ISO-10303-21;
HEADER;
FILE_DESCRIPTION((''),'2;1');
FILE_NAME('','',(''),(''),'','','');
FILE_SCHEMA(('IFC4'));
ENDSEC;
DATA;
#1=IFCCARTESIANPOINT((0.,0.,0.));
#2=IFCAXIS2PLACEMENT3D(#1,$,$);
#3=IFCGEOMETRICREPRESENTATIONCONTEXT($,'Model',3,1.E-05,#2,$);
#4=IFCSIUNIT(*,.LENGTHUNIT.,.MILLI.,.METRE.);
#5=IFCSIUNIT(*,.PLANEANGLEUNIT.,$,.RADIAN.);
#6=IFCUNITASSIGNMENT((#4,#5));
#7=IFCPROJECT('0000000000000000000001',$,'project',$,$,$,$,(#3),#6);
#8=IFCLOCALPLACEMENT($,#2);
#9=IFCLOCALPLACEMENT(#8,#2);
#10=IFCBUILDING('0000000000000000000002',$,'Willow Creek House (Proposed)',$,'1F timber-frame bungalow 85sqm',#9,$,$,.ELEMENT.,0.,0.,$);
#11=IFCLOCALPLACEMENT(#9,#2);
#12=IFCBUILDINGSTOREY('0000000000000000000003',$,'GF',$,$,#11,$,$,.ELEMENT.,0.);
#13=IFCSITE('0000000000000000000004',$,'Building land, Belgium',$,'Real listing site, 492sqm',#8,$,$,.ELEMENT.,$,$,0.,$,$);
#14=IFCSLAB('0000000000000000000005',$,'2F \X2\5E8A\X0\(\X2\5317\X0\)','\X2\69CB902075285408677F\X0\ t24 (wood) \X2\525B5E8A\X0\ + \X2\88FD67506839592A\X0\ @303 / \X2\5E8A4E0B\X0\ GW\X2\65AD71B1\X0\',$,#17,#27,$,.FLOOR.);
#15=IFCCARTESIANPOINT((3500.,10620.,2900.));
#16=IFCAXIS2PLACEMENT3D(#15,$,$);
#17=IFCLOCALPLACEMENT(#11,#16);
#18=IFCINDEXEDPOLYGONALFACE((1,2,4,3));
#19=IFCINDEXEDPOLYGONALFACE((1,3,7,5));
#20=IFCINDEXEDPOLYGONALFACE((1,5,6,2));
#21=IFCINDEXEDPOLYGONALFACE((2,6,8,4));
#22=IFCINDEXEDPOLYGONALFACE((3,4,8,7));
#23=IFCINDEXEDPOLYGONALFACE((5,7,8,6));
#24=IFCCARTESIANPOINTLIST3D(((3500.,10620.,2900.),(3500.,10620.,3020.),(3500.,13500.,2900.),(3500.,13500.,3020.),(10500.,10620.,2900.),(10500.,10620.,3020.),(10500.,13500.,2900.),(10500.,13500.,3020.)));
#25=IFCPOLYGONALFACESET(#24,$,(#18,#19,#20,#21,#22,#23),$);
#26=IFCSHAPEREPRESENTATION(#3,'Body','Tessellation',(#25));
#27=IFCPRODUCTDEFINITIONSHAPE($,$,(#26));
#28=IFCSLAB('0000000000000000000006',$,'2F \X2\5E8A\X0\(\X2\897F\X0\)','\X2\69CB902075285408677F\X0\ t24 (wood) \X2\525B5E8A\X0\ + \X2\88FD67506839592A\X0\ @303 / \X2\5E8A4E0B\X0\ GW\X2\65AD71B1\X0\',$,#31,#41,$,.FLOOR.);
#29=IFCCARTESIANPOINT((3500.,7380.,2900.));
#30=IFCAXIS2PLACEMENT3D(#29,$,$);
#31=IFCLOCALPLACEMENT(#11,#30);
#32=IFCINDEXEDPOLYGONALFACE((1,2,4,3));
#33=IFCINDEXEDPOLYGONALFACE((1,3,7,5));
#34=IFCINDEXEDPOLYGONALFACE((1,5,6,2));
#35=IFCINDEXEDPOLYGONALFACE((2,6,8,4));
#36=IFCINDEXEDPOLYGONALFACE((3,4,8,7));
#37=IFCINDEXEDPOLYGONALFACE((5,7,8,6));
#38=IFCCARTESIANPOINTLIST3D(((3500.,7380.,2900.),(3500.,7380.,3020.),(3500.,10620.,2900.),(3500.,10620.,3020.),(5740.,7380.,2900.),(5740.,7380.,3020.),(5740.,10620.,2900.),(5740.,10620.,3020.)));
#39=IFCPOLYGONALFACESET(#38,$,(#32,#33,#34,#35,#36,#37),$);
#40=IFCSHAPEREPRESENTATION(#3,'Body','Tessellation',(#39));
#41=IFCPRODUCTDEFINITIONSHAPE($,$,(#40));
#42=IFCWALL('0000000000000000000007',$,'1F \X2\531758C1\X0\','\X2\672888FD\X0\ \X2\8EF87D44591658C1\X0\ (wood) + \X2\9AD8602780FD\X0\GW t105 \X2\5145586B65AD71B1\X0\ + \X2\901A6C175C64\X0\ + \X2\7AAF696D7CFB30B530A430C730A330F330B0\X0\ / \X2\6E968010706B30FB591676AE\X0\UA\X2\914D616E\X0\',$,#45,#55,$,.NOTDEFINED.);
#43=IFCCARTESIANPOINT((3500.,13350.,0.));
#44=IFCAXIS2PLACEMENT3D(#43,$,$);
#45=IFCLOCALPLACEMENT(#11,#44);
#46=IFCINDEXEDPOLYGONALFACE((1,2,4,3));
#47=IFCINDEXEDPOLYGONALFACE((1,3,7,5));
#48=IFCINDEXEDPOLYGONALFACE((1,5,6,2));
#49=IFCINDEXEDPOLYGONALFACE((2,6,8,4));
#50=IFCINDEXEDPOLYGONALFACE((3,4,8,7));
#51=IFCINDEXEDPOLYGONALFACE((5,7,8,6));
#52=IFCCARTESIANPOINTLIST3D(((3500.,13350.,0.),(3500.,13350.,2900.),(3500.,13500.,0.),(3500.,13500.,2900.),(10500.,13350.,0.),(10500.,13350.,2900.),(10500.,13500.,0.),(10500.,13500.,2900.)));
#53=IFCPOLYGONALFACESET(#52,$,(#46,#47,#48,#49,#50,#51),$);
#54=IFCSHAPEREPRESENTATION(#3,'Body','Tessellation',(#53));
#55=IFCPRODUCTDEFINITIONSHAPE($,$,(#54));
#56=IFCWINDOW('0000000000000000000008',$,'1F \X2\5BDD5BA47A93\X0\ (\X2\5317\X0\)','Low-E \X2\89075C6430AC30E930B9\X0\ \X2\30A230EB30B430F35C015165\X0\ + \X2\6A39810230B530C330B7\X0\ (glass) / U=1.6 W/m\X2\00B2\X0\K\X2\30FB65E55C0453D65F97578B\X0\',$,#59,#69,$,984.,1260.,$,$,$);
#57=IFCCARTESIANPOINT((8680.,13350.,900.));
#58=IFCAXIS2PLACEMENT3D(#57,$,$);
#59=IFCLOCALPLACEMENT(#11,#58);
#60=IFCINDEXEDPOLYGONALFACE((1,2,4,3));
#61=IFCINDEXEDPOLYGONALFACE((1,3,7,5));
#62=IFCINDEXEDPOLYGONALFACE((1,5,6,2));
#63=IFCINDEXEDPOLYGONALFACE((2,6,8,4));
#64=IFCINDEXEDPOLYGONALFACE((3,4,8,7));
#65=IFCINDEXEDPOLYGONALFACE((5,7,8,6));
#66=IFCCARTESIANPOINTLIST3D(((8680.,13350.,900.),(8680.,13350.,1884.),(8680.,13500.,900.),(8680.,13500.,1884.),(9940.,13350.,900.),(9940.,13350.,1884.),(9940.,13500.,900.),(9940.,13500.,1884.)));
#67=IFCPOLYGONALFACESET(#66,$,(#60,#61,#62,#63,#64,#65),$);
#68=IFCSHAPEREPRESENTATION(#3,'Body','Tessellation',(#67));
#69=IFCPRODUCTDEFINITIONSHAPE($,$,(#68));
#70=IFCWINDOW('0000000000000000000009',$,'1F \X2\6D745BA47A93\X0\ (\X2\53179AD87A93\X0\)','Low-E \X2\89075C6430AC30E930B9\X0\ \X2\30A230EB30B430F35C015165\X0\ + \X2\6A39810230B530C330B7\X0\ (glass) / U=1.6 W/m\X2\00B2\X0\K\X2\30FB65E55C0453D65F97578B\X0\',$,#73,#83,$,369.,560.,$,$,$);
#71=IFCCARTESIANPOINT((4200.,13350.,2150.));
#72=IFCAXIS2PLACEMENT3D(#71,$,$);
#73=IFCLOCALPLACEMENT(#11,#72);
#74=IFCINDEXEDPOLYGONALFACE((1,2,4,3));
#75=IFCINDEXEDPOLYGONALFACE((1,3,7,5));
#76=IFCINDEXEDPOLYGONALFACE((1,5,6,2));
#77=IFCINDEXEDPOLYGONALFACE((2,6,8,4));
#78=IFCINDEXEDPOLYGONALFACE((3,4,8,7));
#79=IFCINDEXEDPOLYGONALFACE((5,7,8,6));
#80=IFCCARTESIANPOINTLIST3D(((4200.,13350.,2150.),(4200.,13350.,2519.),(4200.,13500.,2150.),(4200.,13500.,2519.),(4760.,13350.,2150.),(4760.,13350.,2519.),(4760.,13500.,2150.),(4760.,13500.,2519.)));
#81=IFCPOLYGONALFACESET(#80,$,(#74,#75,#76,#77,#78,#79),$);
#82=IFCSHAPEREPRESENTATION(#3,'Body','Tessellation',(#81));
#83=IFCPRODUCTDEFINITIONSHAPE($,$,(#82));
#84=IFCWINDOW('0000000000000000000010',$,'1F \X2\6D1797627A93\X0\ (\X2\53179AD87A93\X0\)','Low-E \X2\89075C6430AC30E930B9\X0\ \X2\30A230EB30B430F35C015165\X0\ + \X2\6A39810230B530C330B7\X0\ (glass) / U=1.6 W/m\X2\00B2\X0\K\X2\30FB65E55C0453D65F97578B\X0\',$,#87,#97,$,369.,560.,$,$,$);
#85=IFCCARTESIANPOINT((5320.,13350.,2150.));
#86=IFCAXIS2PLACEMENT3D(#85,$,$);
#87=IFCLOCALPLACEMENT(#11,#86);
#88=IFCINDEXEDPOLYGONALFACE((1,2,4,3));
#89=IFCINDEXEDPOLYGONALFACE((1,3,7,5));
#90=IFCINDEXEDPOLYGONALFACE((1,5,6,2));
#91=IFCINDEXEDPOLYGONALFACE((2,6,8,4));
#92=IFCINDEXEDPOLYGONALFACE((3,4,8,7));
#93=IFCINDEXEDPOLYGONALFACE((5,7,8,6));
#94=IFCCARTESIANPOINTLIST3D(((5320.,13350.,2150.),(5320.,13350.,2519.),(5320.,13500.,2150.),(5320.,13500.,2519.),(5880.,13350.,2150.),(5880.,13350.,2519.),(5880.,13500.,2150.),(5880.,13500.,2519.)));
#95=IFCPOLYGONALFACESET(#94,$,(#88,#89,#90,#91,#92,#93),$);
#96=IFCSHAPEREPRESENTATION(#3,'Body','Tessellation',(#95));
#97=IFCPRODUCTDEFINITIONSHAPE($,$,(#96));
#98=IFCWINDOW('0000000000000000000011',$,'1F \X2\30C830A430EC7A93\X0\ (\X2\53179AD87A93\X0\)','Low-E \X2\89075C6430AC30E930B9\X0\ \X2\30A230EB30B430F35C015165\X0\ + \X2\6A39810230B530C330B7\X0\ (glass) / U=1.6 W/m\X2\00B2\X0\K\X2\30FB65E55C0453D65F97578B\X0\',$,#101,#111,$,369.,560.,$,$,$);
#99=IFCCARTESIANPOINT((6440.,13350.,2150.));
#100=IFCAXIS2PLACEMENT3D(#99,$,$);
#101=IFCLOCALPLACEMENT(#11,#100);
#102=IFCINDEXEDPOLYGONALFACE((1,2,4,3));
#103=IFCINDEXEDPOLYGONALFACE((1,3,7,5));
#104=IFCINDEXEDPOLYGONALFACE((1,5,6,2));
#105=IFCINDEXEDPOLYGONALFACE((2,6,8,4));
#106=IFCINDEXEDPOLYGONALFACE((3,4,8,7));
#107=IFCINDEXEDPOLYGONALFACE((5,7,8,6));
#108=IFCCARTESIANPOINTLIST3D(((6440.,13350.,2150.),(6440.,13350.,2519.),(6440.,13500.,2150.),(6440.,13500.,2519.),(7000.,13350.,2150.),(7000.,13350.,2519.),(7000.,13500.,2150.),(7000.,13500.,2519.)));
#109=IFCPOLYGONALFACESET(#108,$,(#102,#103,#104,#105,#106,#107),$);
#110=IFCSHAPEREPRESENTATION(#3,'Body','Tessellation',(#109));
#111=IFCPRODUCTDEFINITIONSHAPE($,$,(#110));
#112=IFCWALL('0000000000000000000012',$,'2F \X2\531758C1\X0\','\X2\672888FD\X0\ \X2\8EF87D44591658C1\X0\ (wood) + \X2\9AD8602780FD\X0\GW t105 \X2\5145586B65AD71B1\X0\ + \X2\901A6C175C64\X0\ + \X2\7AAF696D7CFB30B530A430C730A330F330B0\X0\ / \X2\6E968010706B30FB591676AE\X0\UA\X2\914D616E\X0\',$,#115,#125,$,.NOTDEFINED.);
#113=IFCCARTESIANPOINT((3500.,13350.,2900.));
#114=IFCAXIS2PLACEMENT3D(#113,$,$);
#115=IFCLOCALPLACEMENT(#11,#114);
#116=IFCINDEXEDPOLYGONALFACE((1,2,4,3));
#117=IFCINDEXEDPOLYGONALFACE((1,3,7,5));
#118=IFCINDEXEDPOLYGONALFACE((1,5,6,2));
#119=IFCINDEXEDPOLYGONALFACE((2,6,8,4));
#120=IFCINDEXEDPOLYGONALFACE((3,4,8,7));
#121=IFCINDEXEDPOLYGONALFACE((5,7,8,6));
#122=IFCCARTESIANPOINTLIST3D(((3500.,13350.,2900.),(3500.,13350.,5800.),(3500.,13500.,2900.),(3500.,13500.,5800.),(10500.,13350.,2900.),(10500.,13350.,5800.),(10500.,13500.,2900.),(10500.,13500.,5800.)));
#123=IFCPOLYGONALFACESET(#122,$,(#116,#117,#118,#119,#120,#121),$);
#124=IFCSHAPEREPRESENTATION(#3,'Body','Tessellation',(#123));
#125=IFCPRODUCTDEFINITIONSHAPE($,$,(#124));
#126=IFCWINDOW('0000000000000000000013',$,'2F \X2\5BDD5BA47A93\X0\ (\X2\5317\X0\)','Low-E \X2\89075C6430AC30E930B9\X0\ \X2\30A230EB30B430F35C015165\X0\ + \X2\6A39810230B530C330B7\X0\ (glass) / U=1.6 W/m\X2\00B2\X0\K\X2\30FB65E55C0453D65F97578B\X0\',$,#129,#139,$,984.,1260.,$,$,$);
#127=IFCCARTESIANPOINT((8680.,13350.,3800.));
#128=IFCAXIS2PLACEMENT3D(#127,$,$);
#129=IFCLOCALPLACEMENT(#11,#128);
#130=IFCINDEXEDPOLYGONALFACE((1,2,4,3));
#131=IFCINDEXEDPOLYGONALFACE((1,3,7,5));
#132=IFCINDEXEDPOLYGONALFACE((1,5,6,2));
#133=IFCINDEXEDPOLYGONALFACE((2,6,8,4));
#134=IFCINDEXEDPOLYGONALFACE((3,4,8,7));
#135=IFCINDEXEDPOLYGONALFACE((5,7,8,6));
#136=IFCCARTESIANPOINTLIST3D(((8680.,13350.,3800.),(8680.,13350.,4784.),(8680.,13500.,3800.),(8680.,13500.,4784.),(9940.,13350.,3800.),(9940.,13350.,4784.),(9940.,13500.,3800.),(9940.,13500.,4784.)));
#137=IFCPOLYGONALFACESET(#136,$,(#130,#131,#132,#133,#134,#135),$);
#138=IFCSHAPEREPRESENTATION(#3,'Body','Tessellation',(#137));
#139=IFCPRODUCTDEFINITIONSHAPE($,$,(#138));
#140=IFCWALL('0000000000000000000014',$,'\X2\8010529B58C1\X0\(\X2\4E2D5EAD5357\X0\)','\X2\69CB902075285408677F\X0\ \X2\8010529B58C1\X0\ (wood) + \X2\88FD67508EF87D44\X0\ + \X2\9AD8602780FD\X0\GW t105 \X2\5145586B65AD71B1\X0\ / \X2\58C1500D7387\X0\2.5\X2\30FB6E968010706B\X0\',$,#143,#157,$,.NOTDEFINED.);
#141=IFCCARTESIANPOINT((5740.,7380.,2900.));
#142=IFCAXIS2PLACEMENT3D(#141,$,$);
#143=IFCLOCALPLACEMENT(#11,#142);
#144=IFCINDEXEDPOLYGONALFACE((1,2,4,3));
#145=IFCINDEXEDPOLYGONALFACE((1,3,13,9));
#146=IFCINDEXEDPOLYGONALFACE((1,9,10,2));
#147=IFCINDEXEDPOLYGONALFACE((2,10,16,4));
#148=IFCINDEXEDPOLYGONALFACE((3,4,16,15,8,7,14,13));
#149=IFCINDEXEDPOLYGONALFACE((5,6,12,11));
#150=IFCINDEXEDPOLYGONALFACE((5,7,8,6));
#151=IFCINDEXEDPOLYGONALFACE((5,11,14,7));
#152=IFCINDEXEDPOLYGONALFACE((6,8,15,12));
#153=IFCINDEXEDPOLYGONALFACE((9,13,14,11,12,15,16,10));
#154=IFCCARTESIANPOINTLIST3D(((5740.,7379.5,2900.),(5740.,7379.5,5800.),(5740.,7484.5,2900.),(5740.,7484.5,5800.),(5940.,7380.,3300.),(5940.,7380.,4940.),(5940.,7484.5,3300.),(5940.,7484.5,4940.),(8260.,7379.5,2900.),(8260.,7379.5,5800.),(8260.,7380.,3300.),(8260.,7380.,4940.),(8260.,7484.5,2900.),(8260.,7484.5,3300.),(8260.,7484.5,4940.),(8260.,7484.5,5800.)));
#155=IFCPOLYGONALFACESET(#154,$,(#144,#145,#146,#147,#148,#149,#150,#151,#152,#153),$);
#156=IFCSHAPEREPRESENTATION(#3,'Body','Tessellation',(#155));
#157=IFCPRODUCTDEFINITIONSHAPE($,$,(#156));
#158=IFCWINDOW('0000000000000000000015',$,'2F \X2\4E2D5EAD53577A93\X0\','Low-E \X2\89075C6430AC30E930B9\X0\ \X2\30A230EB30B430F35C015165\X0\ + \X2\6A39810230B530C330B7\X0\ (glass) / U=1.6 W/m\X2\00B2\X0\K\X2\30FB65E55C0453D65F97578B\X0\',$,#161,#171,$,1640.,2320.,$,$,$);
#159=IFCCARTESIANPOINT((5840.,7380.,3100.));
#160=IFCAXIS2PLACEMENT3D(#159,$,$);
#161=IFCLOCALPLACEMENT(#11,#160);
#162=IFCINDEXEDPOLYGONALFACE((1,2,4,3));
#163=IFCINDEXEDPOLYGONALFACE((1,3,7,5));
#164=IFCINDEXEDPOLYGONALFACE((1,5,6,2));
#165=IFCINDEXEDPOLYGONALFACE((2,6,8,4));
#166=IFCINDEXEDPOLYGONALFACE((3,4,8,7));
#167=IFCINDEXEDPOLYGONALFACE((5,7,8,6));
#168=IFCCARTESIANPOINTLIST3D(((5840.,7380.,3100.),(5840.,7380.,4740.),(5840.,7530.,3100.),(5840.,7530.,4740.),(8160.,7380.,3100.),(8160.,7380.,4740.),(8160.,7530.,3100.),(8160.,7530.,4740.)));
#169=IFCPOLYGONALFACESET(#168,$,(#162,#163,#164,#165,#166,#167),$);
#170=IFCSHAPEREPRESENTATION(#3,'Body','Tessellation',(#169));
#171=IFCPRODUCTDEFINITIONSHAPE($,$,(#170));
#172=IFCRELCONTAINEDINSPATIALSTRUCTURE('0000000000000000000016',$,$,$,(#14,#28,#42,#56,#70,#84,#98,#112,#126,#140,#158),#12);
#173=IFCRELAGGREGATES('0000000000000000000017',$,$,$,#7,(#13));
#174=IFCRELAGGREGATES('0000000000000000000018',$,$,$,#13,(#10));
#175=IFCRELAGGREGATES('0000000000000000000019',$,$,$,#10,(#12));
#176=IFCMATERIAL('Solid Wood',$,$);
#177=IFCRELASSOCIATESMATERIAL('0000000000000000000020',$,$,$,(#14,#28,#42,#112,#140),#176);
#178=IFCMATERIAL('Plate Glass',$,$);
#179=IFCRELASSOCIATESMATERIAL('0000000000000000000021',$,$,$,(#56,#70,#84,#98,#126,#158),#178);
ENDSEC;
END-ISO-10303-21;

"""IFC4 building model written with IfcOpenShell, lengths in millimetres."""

from ifc_helpers import new_model, si_unit, frame, frame_2d, origin, place, context, project, spatial, rectangle, extrude, material, element, fill, save


model = new_model("IFC4")

# Units and contexts
model_context = context("Model", 3, precision=1e-05, world=origin())
ifc_project = project(units=[si_unit("LENGTHUNIT", "METRE", prefix="MILLI"), si_unit("PLANEANGLEUNIT", "RADIAN")], contexts=[model_context])

# Site, building, storey
site_placement = place(None, origin())
site = spatial("IfcSite", under=ifc_project, at=site_placement, Name="Building land, Belgium", ObjectType="Real listing site, 492sqm", CompositionType="ELEMENT", RefElevation=0.0)
building_placement = place(site_placement, origin())
building = spatial("IfcBuilding", under=site, at=building_placement, Name="Willow Creek House (Proposed)", ObjectType="1F timber-frame bungalow 85sqm", CompositionType="ELEMENT", ElevationOfRefHeight=0.0, ElevationOfTerrain=0.0)
storey_placement = place(building_placement, origin())
storey = spatial("IfcBuildingStorey", under=building, at=storey_placement, Name="GF", CompositionType="ELEMENT", Elevation=0.0)

# Slabs
ifc_material_1 = material(Name="Solid Wood")
slab_1_placement = place(storey_placement, frame((3500.0, 10620.0, 2900.0)))
element("IfcSlab", 1, at=slab_1_placement, inside=storey, material=ifc_material_1, Name="2F 床(北)", Description="構造用合板 t24 (wood) 剛床 + 製材根太 @303 / 床下 GW断熱", PredefinedType="FLOOR", context=model_context, shape_type="SweptSolid", body=[
    extrude(rectangle(XDim=7000.0, YDim=2880.0, at=frame_2d((3500.0, 1440.0))), frame((3500.0, 10620.0, 2900.0)), (0.0, 0.0, 1.0), 120.0),
])
slab_2_placement = place(storey_placement, frame((3500.0, 7380.0, 2900.0)))
element("IfcSlab", 2, at=slab_2_placement, inside=storey, material=ifc_material_1, Name="2F 床(西)", Description="構造用合板 t24 (wood) 剛床 + 製材根太 @303 / 床下 GW断熱", PredefinedType="FLOOR", context=model_context, shape_type="SweptSolid", body=[
    extrude(rectangle(XDim=2240.0, YDim=3240.0, at=frame_2d((1120.0, 1620.0))), frame((3500.0, 7380.0, 2900.0)), (0.0, 0.0, 1.0), 120.0),
])

# Wall, openings, windows
wall_1_placement = place(storey_placement, frame((3500.0, 13350.0, 0.0)))
wall_1 = element("IfcWall", 3, at=wall_1_placement, inside=storey, material=ifc_material_1, Name="1F 北壁", Description="木製 軸組外壁 (wood) + 高性能GW t105 充填断熱 + 通気層 + 窯業系サイディング / 準耐火・外皮UA配慮", PredefinedType="NOTDEFINED", context=model_context, shape_type="SweptSolid", body=[
    extrude(rectangle(XDim=7000.0, YDim=150.0, at=frame_2d((3500.0, 75.0))), frame((3500.0, 13350.0, 0.0)), (0.0, 0.0, 1.0), 2900.0),
])
opening_1_placement = place(storey_placement, frame((8680.0, 13350.0, 900.0)))
opening_1 = element("IfcOpeningElement", 4, at=opening_1_placement, cuts=wall_1, PredefinedType="NOTDEFINED", context=model_context, shape_type="SweptSolid", body=[
    extrude(rectangle(XDim=1260.0, YDim=150.0, at=frame_2d((630.0, 75.0))), frame((8680.0, 13350.0, 900.0)), (0.0, 0.0, 1.0), 984.0),
])
opening_2_placement = place(storey_placement, frame((4200.0, 13350.0, 2150.0)))
opening_2 = element("IfcOpeningElement", 5, at=opening_2_placement, cuts=wall_1, PredefinedType="NOTDEFINED", context=model_context, shape_type="SweptSolid", body=[
    extrude(rectangle(XDim=560.0, YDim=150.0, at=frame_2d((280.0, 75.0))), frame((4200.0, 13350.0, 2150.0)), (0.0, 0.0, 1.0), 369.0),
])
opening_3_placement = place(storey_placement, frame((5320.0, 13350.0, 2150.0)))
opening_3 = element("IfcOpeningElement", 6, at=opening_3_placement, cuts=wall_1, PredefinedType="NOTDEFINED", context=model_context, shape_type="SweptSolid", body=[
    extrude(rectangle(XDim=560.0, YDim=150.0, at=frame_2d((280.0, 75.0))), frame((5320.0, 13350.0, 2150.0)), (0.0, 0.0, 1.0), 369.0),
])
opening_4_placement = place(storey_placement, frame((6440.0, 13350.0, 2150.0)))
opening_4 = element("IfcOpeningElement", 7, at=opening_4_placement, cuts=wall_1, PredefinedType="NOTDEFINED", context=model_context, shape_type="SweptSolid", body=[
    extrude(rectangle(XDim=560.0, YDim=150.0, at=frame_2d((280.0, 75.0))), frame((6440.0, 13350.0, 2150.0)), (0.0, 0.0, 1.0), 369.0),
])
ifc_material_2 = material(Name="Plate Glass")
window_1_placement = place(storey_placement, frame((8680.0, 13350.0, 900.0)))
window_1 = element("IfcWindow", 8, at=window_1_placement, inside=storey, material=ifc_material_2, Name="1F 寝室窓 (北)", Description="Low-E 複層ガラス アルゴン封入 + 樹脂サッシ (glass) / U=1.6 W/m²K・日射取得型", OverallHeight=984.0, OverallWidth=1260.0, context=model_context, shape_type="SweptSolid", body=[
    extrude(rectangle(XDim=1260.0, YDim=150.0, at=frame_2d((630.0, 75.0))), frame((8680.0, 13350.0, 900.0)), (0.0, 0.0, 1.0), 984.0),
])
fill(opening_1, window_1)
window_2_placement = place(storey_placement, frame((4200.0, 13350.0, 2150.0)))
window_2 = element("IfcWindow", 9, at=window_2_placement, inside=storey, material=ifc_material_2, Name="1F 浴室窓 (北高窓)", Description="Low-E 複層ガラス アルゴン封入 + 樹脂サッシ (glass) / U=1.6 W/m²K・日射取得型", OverallHeight=369.0, OverallWidth=560.0, context=model_context, shape_type="SweptSolid", body=[
    extrude(rectangle(XDim=560.0, YDim=150.0, at=frame_2d((280.0, 75.0))), frame((4200.0, 13350.0, 2150.0)), (0.0, 0.0, 1.0), 369.0),
])
fill(opening_2, window_2)
window_3_placement = place(storey_placement, frame((5320.0, 13350.0, 2150.0)))
window_3 = element("IfcWindow", 10, at=window_3_placement, inside=storey, material=ifc_material_2, Name="1F 洗面窓 (北高窓)", Description="Low-E 複層ガラス アルゴン封入 + 樹脂サッシ (glass) / U=1.6 W/m²K・日射取得型", OverallHeight=369.0, OverallWidth=560.0, context=model_context, shape_type="SweptSolid", body=[
    extrude(rectangle(XDim=560.0, YDim=150.0, at=frame_2d((280.0, 75.0))), frame((5320.0, 13350.0, 2150.0)), (0.0, 0.0, 1.0), 369.0),
])
fill(opening_3, window_3)
window_4_placement = place(storey_placement, frame((6440.0, 13350.0, 2150.0)))
window_4 = element("IfcWindow", 11, at=window_4_placement, inside=storey, material=ifc_material_2, Name="1F トイレ窓 (北高窓)", Description="Low-E 複層ガラス アルゴン封入 + 樹脂サッシ (glass) / U=1.6 W/m²K・日射取得型", OverallHeight=369.0, OverallWidth=560.0, context=model_context, shape_type="SweptSolid", body=[
    extrude(rectangle(XDim=560.0, YDim=150.0, at=frame_2d((280.0, 75.0))), frame((6440.0, 13350.0, 2150.0)), (0.0, 0.0, 1.0), 369.0),
])
fill(opening_4, window_4)

# Walls, openings, windows
wall_2_placement = place(storey_placement, frame((3500.0, 13350.0, 2900.0)))
wall_2 = element("IfcWall", 12, at=wall_2_placement, inside=storey, material=ifc_material_1, Name="2F 北壁", Description="木製 軸組外壁 (wood) + 高性能GW t105 充填断熱 + 通気層 + 窯業系サイディング / 準耐火・外皮UA配慮", PredefinedType="NOTDEFINED", context=model_context, shape_type="SweptSolid", body=[
    extrude(rectangle(XDim=7000.0, YDim=150.0, at=frame_2d((3500.0, 75.0))), frame((3500.0, 13350.0, 2900.0)), (0.0, 0.0, 1.0), 2900.0),
])
opening_5_placement = place(storey_placement, frame((8680.0, 13350.0, 3800.0)))
opening_5 = element("IfcOpeningElement", 13, at=opening_5_placement, cuts=wall_2, PredefinedType="NOTDEFINED", context=model_context, shape_type="SweptSolid", body=[
    extrude(rectangle(XDim=1260.0, YDim=150.0, at=frame_2d((630.0, 75.0))), frame((8680.0, 13350.0, 3800.0)), (0.0, 0.0, 1.0), 984.0),
])
window_5_placement = place(storey_placement, frame((8680.0, 13350.0, 3800.0)))
window_5 = element("IfcWindow", 14, at=window_5_placement, inside=storey, material=ifc_material_2, Name="2F 寝室窓 (北)", Description="Low-E 複層ガラス アルゴン封入 + 樹脂サッシ (glass) / U=1.6 W/m²K・日射取得型", OverallHeight=984.0, OverallWidth=1260.0, context=model_context, shape_type="SweptSolid", body=[
    extrude(rectangle(XDim=1260.0, YDim=150.0, at=frame_2d((630.0, 75.0))), frame((8680.0, 13350.0, 3800.0)), (0.0, 0.0, 1.0), 984.0),
])
fill(opening_5, window_5)
wall_3_placement = place(storey_placement, frame((5740.0, 7380.0, 2900.0)))
wall_3 = element("IfcWall", 15, at=wall_3_placement, inside=storey, material=ifc_material_1, Name="耐力壁(中庭南)", Description="構造用合板 耐力壁 (wood) + 製材軸組 + 高性能GW t105 充填断熱 / 壁倍率2.5・準耐火", PredefinedType="NOTDEFINED", context=model_context, shape_type="SweptSolid", body=[
    extrude(rectangle(XDim=2520.0, YDim=105.0, at=frame_2d((1260.0, 52.0))), frame((5740.0, 7380.0, 2900.0)), (0.0, 0.0, 1.0), 2900.0),
])
opening_6_placement = place(storey_placement, frame((5840.0, 7380.0, 3100.0)))
opening_6 = element("IfcOpeningElement", 16, at=opening_6_placement, cuts=wall_3, PredefinedType="NOTDEFINED", context=model_context, shape_type="SweptSolid", body=[
    extrude(rectangle(XDim=2320.0, YDim=150.0, at=frame_2d((1160.0, 75.0))), frame((5840.0, 7380.0, 3100.0)), (0.0, 0.0, 1.0), 1640.0),
])
window_6_placement = place(storey_placement, frame((5840.0, 7380.0, 3100.0)))
window_6 = element("IfcWindow", 17, at=window_6_placement, inside=storey, material=ifc_material_2, Name="2F 中庭南窓", Description="Low-E 複層ガラス アルゴン封入 + 樹脂サッシ (glass) / U=1.6 W/m²K・日射取得型", OverallHeight=1640.0, OverallWidth=2320.0, context=model_context, shape_type="SweptSolid", body=[
    extrude(rectangle(XDim=2320.0, YDim=150.0, at=frame_2d((1160.0, 75.0))), frame((5840.0, 7380.0, 3100.0)), (0.0, 0.0, 1.0), 1640.0),
])
fill(opening_6, window_6)

save(model, "model.ifc")
